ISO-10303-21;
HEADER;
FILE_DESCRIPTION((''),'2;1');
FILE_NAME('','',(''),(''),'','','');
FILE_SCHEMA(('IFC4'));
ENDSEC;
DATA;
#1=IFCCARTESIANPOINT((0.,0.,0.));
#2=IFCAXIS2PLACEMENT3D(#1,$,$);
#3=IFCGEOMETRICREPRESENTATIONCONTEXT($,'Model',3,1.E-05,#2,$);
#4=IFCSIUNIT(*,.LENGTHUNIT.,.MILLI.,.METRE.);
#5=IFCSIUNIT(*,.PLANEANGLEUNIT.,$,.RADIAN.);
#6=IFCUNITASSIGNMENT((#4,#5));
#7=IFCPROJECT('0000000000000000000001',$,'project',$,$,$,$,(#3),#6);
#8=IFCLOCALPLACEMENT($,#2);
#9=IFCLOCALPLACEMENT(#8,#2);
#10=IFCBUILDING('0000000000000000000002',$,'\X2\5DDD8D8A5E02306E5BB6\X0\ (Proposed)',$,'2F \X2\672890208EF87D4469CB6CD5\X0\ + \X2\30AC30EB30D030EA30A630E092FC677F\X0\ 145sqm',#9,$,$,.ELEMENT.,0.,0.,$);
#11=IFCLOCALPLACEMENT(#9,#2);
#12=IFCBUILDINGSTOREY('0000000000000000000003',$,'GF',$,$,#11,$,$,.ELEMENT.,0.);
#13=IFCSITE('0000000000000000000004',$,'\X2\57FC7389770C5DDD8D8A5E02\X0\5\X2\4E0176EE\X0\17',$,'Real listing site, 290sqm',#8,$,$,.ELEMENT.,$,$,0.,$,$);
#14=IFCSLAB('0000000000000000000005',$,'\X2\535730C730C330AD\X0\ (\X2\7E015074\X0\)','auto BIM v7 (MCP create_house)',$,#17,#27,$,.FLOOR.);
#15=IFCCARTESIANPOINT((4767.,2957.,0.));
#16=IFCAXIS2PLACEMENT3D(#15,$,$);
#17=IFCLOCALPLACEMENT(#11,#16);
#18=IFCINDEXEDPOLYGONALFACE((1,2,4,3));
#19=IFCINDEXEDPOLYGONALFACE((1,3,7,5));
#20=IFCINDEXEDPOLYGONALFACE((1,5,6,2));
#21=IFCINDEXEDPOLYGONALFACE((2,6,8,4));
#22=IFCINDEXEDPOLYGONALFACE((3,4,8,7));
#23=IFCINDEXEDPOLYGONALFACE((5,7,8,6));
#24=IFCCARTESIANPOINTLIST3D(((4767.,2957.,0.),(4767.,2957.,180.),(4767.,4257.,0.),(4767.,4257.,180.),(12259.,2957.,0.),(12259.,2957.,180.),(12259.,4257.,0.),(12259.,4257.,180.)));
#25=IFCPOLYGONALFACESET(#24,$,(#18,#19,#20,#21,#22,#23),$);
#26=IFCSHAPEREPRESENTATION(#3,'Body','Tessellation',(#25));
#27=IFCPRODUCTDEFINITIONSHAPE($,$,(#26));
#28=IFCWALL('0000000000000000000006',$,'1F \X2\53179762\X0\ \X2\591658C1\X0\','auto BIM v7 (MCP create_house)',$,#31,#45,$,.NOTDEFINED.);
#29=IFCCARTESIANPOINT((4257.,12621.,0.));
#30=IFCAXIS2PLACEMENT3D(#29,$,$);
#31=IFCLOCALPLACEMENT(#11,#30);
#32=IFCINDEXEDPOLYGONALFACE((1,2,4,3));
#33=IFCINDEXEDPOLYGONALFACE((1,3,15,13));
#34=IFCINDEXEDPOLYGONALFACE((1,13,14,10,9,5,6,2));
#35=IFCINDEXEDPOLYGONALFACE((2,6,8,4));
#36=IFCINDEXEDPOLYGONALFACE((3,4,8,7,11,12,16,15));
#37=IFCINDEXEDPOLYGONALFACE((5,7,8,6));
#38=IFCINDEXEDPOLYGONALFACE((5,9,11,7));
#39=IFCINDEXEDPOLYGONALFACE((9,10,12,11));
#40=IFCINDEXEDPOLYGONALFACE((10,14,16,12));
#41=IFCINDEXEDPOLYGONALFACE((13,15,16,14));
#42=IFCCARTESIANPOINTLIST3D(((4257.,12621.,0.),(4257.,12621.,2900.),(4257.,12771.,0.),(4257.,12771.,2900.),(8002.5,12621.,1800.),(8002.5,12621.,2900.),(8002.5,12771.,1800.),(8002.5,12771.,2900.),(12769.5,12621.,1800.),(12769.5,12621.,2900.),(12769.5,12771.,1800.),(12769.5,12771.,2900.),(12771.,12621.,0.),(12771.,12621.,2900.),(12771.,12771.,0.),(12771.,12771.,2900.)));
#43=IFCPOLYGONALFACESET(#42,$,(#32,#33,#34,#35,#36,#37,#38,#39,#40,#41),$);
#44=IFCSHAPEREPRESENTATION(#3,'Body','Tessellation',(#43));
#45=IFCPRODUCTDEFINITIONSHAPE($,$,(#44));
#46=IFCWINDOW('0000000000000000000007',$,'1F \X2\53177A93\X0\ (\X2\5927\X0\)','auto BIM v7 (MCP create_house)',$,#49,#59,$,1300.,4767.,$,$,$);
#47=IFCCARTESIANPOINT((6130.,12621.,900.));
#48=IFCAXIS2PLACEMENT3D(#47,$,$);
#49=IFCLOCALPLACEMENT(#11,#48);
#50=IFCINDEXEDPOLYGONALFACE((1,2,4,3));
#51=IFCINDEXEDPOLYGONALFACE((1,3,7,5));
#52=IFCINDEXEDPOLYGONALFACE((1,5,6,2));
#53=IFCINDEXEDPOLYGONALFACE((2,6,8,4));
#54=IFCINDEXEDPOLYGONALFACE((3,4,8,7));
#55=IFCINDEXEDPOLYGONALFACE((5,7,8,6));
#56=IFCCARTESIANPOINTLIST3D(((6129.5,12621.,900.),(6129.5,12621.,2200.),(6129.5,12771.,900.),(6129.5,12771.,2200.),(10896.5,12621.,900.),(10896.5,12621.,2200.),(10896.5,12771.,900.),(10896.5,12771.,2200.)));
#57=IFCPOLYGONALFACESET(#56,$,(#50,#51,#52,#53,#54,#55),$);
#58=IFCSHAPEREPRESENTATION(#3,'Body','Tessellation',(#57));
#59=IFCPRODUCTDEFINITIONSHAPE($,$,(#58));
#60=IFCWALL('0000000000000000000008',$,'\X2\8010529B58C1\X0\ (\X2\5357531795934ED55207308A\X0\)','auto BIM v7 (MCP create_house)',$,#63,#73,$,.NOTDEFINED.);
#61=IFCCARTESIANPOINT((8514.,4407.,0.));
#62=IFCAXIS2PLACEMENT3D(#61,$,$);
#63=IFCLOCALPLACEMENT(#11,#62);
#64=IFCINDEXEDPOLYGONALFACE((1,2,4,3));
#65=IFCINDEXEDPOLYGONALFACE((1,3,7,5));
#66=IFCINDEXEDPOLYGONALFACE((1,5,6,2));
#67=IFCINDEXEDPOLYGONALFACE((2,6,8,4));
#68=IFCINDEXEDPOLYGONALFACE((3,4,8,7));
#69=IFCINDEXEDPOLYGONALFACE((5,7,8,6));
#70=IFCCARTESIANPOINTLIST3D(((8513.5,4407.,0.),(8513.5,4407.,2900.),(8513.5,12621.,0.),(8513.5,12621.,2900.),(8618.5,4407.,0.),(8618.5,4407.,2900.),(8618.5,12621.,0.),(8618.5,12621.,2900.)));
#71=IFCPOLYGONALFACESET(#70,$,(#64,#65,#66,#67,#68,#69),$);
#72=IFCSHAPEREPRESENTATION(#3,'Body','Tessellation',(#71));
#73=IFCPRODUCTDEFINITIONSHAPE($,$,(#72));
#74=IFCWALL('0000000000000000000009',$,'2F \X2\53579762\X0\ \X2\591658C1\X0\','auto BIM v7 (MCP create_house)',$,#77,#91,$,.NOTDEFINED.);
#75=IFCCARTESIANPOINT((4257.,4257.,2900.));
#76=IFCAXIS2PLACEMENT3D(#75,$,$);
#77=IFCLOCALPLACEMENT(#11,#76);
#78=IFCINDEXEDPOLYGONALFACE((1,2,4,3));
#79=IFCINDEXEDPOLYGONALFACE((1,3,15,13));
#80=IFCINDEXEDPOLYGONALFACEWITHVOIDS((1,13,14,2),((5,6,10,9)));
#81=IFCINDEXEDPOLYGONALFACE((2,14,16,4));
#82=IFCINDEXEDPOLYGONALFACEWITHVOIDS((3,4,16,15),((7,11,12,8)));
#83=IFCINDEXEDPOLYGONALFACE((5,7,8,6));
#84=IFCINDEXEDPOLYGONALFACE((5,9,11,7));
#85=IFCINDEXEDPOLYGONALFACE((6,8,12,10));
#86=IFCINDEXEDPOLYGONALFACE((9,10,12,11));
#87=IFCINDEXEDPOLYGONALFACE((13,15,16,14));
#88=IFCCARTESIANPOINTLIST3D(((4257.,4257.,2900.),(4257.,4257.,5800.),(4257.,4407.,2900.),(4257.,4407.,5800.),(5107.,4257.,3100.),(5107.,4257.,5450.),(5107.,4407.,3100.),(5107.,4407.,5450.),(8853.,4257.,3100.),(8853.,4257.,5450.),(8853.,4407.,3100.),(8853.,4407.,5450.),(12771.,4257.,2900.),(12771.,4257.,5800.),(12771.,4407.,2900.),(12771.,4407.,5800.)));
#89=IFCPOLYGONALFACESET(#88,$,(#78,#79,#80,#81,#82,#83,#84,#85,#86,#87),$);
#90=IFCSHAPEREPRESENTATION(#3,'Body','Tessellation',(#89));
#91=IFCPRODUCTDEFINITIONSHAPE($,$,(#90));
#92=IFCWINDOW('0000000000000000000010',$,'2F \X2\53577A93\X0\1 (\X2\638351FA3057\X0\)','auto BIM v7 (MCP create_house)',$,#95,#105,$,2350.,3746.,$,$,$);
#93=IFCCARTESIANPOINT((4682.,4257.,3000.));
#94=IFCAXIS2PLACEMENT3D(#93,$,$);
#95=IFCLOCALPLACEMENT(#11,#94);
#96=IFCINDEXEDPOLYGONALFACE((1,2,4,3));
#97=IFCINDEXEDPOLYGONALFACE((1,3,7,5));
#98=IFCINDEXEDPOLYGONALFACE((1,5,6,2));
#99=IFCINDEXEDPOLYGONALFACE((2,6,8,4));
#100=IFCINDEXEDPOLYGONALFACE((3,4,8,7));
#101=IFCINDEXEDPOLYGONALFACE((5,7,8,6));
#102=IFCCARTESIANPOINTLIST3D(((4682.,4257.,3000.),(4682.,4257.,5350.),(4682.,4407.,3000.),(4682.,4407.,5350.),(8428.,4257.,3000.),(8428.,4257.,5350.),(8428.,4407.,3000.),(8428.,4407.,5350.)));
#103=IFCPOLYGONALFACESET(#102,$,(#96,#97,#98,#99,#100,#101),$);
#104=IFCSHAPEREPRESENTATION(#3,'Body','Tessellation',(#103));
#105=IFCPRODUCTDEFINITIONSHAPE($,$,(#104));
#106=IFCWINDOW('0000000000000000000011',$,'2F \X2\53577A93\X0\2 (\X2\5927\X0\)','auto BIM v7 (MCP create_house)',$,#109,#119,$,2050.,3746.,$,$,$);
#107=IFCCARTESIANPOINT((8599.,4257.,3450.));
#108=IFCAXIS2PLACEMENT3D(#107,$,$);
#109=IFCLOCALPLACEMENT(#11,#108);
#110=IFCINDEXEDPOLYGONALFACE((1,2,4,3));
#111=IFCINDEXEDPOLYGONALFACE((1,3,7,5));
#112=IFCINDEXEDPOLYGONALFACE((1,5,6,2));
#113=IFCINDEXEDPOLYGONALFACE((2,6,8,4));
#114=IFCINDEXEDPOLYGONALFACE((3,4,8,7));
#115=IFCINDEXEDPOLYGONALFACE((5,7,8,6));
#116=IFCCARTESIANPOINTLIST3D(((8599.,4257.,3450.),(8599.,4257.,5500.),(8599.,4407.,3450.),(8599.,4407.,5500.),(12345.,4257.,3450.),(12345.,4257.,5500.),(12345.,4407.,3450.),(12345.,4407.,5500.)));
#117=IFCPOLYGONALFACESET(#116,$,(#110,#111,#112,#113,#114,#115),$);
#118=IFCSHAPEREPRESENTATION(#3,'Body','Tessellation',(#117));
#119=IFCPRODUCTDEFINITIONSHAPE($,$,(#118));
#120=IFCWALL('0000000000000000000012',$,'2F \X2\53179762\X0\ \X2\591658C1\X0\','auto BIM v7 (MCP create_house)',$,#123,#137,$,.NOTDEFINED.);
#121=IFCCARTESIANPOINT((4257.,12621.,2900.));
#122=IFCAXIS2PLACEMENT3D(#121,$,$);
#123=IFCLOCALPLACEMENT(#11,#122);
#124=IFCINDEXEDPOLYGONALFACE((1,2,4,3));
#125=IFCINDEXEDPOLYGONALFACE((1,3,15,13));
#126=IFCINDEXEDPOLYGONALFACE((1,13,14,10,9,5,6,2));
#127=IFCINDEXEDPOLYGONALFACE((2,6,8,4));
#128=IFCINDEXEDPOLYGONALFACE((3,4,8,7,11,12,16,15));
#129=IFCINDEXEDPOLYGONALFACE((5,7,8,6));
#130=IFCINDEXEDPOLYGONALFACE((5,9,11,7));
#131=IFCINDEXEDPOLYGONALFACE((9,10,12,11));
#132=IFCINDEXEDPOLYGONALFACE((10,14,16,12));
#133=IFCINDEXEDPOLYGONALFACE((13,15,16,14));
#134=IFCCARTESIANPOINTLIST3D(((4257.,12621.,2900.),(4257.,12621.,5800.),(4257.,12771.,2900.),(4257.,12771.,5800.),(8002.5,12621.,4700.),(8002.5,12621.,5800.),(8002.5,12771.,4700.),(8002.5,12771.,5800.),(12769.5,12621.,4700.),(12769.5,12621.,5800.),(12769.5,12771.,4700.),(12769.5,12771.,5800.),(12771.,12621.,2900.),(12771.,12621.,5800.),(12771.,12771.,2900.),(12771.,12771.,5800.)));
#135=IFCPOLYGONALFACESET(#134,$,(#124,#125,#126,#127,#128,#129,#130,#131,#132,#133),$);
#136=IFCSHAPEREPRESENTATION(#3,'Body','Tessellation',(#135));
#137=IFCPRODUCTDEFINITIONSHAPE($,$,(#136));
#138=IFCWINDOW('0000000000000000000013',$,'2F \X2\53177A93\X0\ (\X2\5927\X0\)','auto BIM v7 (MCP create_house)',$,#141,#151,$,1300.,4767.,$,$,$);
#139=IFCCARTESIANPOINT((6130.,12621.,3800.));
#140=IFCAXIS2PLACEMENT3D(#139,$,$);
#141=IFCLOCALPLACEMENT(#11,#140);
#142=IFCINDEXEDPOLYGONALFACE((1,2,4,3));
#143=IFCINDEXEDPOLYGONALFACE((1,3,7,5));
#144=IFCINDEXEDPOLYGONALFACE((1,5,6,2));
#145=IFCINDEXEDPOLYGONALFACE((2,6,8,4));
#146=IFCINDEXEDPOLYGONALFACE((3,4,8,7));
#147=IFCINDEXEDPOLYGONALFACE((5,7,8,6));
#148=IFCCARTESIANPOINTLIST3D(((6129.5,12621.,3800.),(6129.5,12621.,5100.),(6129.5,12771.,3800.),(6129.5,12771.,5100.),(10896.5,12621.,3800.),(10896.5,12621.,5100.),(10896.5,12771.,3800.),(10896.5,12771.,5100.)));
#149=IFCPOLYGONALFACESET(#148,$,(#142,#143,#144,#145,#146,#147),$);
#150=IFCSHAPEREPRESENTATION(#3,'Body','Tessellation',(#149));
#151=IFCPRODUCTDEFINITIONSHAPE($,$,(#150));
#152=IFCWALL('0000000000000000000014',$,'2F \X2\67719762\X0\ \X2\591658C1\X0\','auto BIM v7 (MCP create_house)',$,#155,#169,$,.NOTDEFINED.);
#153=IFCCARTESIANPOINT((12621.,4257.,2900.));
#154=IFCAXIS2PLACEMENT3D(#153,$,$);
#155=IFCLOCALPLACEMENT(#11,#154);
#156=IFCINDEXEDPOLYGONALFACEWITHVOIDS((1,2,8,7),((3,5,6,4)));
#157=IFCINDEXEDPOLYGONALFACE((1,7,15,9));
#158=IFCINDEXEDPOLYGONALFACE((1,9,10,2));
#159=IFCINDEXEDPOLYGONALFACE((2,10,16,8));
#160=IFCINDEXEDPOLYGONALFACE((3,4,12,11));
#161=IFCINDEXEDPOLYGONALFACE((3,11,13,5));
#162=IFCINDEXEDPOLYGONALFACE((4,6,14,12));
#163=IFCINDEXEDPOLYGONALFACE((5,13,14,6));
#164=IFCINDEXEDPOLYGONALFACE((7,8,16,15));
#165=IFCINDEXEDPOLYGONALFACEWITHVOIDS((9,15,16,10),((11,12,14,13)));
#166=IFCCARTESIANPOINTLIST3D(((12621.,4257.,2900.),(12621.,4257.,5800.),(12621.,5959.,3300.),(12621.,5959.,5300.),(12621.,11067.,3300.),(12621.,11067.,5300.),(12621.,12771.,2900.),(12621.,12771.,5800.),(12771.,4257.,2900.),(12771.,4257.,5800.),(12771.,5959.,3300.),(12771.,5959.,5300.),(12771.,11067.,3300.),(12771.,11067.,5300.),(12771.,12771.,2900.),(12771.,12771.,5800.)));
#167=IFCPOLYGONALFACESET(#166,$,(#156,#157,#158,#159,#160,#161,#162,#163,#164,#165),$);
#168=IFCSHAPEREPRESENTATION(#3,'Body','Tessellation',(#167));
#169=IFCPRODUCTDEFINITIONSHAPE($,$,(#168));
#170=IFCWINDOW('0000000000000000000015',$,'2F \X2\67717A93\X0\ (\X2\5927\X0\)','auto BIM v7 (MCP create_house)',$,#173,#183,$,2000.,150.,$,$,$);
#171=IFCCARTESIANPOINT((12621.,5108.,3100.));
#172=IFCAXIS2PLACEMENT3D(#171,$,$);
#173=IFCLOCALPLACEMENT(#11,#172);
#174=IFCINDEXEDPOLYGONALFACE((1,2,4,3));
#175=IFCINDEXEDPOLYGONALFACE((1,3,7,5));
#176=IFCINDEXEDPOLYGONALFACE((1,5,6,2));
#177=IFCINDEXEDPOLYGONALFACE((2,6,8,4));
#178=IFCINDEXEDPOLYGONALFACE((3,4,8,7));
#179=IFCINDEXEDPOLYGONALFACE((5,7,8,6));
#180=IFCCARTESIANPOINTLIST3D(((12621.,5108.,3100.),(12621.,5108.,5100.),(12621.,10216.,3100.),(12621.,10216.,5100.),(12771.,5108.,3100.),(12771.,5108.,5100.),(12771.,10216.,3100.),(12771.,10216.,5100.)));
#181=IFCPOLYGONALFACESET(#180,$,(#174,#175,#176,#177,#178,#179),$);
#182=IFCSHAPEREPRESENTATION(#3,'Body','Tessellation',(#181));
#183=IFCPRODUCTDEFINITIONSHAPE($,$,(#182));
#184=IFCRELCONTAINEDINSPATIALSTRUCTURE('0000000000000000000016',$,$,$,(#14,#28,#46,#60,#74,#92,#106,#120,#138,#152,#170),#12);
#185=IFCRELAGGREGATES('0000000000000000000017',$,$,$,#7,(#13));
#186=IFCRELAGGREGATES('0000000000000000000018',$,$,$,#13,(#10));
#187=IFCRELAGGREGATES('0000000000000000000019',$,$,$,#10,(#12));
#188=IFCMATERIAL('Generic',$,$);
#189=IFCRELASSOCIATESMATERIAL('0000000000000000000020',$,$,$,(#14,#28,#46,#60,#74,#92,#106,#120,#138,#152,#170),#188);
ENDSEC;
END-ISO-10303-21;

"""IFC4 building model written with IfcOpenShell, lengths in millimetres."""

from ifc_helpers import new_model, si_unit, frame, frame_2d, origin, place, context, project, spatial, rectangle, extrude, material, element, fill, save


model = new_model("IFC4")

# Units and contexts
model_context = context("Model", 3, precision=1e-05, world=origin())
ifc_project = project(units=[si_unit("LENGTHUNIT", "METRE", prefix="MILLI"), si_unit("PLANEANGLEUNIT", "RADIAN")], contexts=[model_context])

# Site, building, storey
site_placement = place(None, origin())
site = spatial("IfcSite", under=ifc_project, at=site_placement, Name="埼玉県川越市5丁目17", ObjectType="Real listing site, 290sqm", CompositionType="ELEMENT", RefElevation=0.0)
building_placement = place(site_placement, origin())
building = spatial("IfcBuilding", under=site, at=building_placement, Name="川越市の家 (Proposed)", ObjectType="2F 木造軸組構法 + ガルバリウム鋼板 145sqm", CompositionType="ELEMENT", ElevationOfRefHeight=0.0, ElevationOfTerrain=0.0)
storey_placement = place(building_placement, origin())
storey = spatial("IfcBuildingStorey", under=building, at=storey_placement, Name="GF", CompositionType="ELEMENT", Elevation=0.0)

# Slab
ifc_material = material(Name="Generic")
slab_1_placement = place(storey_placement, frame((4767.0, 2957.0, 0.0)))
element("IfcSlab", 1, at=slab_1_placement, inside=storey, material=ifc_material, Name="南デッキ (縁側)", Description="auto BIM v7 (MCP create_house)", PredefinedType="FLOOR", context=model_context, shape_type="SweptSolid", body=[
    extrude(rectangle(XDim=7492.0, YDim=1300.0, at=frame_2d((3746.0, 650.0))), frame((4767.0, 2957.0, 0.0)), (0.0, 0.0, 1.0), 180.0),
])

# Wall, opening, window
wall_1_placement = place(storey_placement, frame((4257.0, 12621.0, 0.0)))
wall_1 = element("IfcWall", 2, at=wall_1_placement, inside=storey, material=ifc_material, Name="1F 北面 外壁", Description="auto BIM v7 (MCP create_house)", PredefinedType="NOTDEFINED", context=model_context, shape_type="SweptSolid", body=[
    extrude(rectangle(XDim=8514.0, YDim=150.0, at=frame_2d((4257.0, 75.0))), frame((4257.0, 12621.0, 0.0)), (0.0, 0.0, 1.0), 2900.0),
])
opening_1_placement = place(storey_placement, frame((6130.0, 12621.0, 900.0)))
opening_1 = element("IfcOpeningElement", 3, at=opening_1_placement, cuts=wall_1, PredefinedType="NOTDEFINED", context=model_context, shape_type="SweptSolid", body=[
    extrude(rectangle(XDim=4767.0, YDim=150.0, at=frame_2d((2383.0, 75.0))), frame((6130.0, 12621.0, 900.0)), (0.0, 0.0, 1.0), 1300.0),
])
window_1_placement = place(storey_placement, frame((6130.0, 12621.0, 900.0)))
window_1 = element("IfcWindow", 4, at=window_1_placement, inside=storey, material=ifc_material, Name="1F 北窓 (大)", Description="auto BIM v7 (MCP create_house)", OverallHeight=1300.0, OverallWidth=4767.0, context=model_context, shape_type="SweptSolid", body=[
    extrude(rectangle(XDim=4767.0, YDim=150.0, at=frame_2d((2383.0, 75.0))), frame((6130.0, 12621.0, 900.0)), (0.0, 0.0, 1.0), 1300.0),
])
fill(opening_1, window_1)

# Wall
wall_2_placement = place(storey_placement, frame((8514.0, 4407.0, 0.0)))
element("IfcWall", 5, at=wall_2_placement, inside=storey, material=ifc_material, Name="耐力壁 (南北間仕切り)", Description="auto BIM v7 (MCP create_house)", PredefinedType="NOTDEFINED", context=model_context, shape_type="SweptSolid", body=[
    extrude(rectangle(XDim=105.0, YDim=8214.0, at=frame_2d((52.0, 4107.0))), frame((8514.0, 4407.0, 0.0)), (0.0, 0.0, 1.0), 2900.0),
])

# Wall, openings, windows
wall_3_placement = place(storey_placement, frame((4257.0, 4257.0, 2900.0)))
wall_3 = element("IfcWall", 6, at=wall_3_placement, inside=storey, material=ifc_material, Name="2F 南面 外壁", Description="auto BIM v7 (MCP create_house)", PredefinedType="NOTDEFINED", context=model_context, shape_type="SweptSolid", body=[
    extrude(rectangle(XDim=8514.0, YDim=150.0, at=frame_2d((4257.0, 75.0))), frame((4257.0, 4257.0, 2900.0)), (0.0, 0.0, 1.0), 2900.0),
])
opening_2_placement = place(storey_placement, frame((4682.0, 4257.0, 3000.0)))
opening_2 = element("IfcOpeningElement", 7, at=opening_2_placement, cuts=wall_3, PredefinedType="NOTDEFINED", context=model_context, shape_type="SweptSolid", body=[
    extrude(rectangle(XDim=3746.0, YDim=150.0, at=frame_2d((1873.0, 75.0))), frame((4682.0, 4257.0, 3000.0)), (0.0, 0.0, 1.0), 2350.0),
])
opening_3_placement = place(storey_placement, frame((8599.0, 4257.0, 3450.0)))
opening_3 = element("IfcOpeningElement", 8, at=opening_3_placement, cuts=wall_3, PredefinedType="NOTDEFINED", context=model_context, shape_type="SweptSolid", body=[
    extrude(rectangle(XDim=3746.0, YDim=150.0, at=frame_2d((1873.0, 75.0))), frame((8599.0, 4257.0, 3450.0)), (0.0, 0.0, 1.0), 2050.0),
])
window_2_placement = place(storey_placement, frame((4682.0, 4257.0, 3000.0)))
window_2 = element("IfcWindow", 9, at=window_2_placement, inside=storey, material=ifc_material, Name="2F 南窓1 (掃出し)", Description="auto BIM v7 (MCP create_house)", OverallHeight=2350.0, OverallWidth=3746.0, context=model_context, shape_type="SweptSolid", body=[
    extrude(rectangle(XDim=3746.0, YDim=150.0, at=frame_2d((1873.0, 75.0))), frame((4682.0, 4257.0, 3000.0)), (0.0, 0.0, 1.0), 2350.0),
])
fill(opening_2, window_2)
window_3_placement = place(storey_placement, frame((8599.0, 4257.0, 3450.0)))
window_3 = element("IfcWindow", 10, at=window_3_placement, inside=storey, material=ifc_material, Name="2F 南窓2 (大)", Description="auto BIM v7 (MCP create_house)", OverallHeight=2050.0, OverallWidth=3746.0, context=model_context, shape_type="SweptSolid", body=[
    extrude(rectangle(XDim=3746.0, YDim=150.0, at=frame_2d((1873.0, 75.0))), frame((8599.0, 4257.0, 3450.0)), (0.0, 0.0, 1.0), 2050.0),
])
fill(opening_3, window_3)

# Walls, openings, windows
wall_4_placement = place(storey_placement, frame((4257.0, 12621.0, 2900.0)))
wall_4 = element("IfcWall", 11, at=wall_4_placement, inside=storey, material=ifc_material, Name="2F 北面 外壁", Description="auto BIM v7 (MCP create_house)", PredefinedType="NOTDEFINED", context=model_context, shape_type="SweptSolid", body=[
    extrude(rectangle(XDim=8514.0, YDim=150.0, at=frame_2d((4257.0, 75.0))), frame((4257.0, 12621.0, 2900.0)), (0.0, 0.0, 1.0), 2900.0),
])
opening_4_placement = place(storey_placement, frame((6130.0, 12621.0, 3800.0)))
opening_4 = element("IfcOpeningElement", 12, at=opening_4_placement, cuts=wall_4, PredefinedType="NOTDEFINED", context=model_context, shape_type="SweptSolid", body=[
    extrude(rectangle(XDim=4767.0, YDim=150.0, at=frame_2d((2383.0, 75.0))), frame((6130.0, 12621.0, 3800.0)), (0.0, 0.0, 1.0), 1300.0),
])
window_4_placement = place(storey_placement, frame((6130.0, 12621.0, 3800.0)))
window_4 = element("IfcWindow", 13, at=window_4_placement, inside=storey, material=ifc_material, Name="2F 北窓 (大)", Description="auto BIM v7 (MCP create_house)", OverallHeight=1300.0, OverallWidth=4767.0, context=model_context, shape_type="SweptSolid", body=[
    extrude(rectangle(XDim=4767.0, YDim=150.0, at=frame_2d((2383.0, 75.0))), frame((6130.0, 12621.0, 3800.0)), (0.0, 0.0, 1.0), 1300.0),
])
fill(opening_4, window_4)
wall_5_placement = place(storey_placement, frame((12621.0, 4257.0, 2900.0)))
wall_5 = element("IfcWall", 14, at=wall_5_placement, inside=storey, material=ifc_material, Name="2F 東面 外壁", Description="auto BIM v7 (MCP create_house)", PredefinedType="NOTDEFINED", context=model_context, shape_type="SweptSolid", body=[
    extrude(rectangle(XDim=150.0, YDim=8514.0, at=frame_2d((75.0, 4257.0))), frame((12621.0, 4257.0, 2900.0)), (0.0, 0.0, 1.0), 2900.0),
])
opening_5_placement = place(storey_placement, frame((12621.0, 5108.0, 3100.0)))
opening_5 = element("IfcOpeningElement", 15, at=opening_5_placement, cuts=wall_5, PredefinedType="NOTDEFINED", context=model_context, shape_type="SweptSolid", body=[
    extrude(rectangle(XDim=150.0, YDim=5108.0, at=frame_2d((75.0, 2554.0))), frame((12621.0, 5108.0, 3100.0)), (0.0, 0.0, 1.0), 2000.0),
])
window_5_placement = place(storey_placement, frame((12621.0, 5108.0, 3100.0)))
window_5 = element("IfcWindow", 16, at=window_5_placement, inside=storey, material=ifc_material, Name="2F 東窓 (大)", Description="auto BIM v7 (MCP create_house)", OverallHeight=2000.0, OverallWidth=150.0, context=model_context, shape_type="SweptSolid", body=[
    extrude(rectangle(XDim=150.0, YDim=5108.0, at=frame_2d((75.0, 2554.0))), frame((12621.0, 5108.0, 3100.0)), (0.0, 0.0, 1.0), 2000.0),
])
fill(opening_5, window_5)

save(model, "model.ifc")
